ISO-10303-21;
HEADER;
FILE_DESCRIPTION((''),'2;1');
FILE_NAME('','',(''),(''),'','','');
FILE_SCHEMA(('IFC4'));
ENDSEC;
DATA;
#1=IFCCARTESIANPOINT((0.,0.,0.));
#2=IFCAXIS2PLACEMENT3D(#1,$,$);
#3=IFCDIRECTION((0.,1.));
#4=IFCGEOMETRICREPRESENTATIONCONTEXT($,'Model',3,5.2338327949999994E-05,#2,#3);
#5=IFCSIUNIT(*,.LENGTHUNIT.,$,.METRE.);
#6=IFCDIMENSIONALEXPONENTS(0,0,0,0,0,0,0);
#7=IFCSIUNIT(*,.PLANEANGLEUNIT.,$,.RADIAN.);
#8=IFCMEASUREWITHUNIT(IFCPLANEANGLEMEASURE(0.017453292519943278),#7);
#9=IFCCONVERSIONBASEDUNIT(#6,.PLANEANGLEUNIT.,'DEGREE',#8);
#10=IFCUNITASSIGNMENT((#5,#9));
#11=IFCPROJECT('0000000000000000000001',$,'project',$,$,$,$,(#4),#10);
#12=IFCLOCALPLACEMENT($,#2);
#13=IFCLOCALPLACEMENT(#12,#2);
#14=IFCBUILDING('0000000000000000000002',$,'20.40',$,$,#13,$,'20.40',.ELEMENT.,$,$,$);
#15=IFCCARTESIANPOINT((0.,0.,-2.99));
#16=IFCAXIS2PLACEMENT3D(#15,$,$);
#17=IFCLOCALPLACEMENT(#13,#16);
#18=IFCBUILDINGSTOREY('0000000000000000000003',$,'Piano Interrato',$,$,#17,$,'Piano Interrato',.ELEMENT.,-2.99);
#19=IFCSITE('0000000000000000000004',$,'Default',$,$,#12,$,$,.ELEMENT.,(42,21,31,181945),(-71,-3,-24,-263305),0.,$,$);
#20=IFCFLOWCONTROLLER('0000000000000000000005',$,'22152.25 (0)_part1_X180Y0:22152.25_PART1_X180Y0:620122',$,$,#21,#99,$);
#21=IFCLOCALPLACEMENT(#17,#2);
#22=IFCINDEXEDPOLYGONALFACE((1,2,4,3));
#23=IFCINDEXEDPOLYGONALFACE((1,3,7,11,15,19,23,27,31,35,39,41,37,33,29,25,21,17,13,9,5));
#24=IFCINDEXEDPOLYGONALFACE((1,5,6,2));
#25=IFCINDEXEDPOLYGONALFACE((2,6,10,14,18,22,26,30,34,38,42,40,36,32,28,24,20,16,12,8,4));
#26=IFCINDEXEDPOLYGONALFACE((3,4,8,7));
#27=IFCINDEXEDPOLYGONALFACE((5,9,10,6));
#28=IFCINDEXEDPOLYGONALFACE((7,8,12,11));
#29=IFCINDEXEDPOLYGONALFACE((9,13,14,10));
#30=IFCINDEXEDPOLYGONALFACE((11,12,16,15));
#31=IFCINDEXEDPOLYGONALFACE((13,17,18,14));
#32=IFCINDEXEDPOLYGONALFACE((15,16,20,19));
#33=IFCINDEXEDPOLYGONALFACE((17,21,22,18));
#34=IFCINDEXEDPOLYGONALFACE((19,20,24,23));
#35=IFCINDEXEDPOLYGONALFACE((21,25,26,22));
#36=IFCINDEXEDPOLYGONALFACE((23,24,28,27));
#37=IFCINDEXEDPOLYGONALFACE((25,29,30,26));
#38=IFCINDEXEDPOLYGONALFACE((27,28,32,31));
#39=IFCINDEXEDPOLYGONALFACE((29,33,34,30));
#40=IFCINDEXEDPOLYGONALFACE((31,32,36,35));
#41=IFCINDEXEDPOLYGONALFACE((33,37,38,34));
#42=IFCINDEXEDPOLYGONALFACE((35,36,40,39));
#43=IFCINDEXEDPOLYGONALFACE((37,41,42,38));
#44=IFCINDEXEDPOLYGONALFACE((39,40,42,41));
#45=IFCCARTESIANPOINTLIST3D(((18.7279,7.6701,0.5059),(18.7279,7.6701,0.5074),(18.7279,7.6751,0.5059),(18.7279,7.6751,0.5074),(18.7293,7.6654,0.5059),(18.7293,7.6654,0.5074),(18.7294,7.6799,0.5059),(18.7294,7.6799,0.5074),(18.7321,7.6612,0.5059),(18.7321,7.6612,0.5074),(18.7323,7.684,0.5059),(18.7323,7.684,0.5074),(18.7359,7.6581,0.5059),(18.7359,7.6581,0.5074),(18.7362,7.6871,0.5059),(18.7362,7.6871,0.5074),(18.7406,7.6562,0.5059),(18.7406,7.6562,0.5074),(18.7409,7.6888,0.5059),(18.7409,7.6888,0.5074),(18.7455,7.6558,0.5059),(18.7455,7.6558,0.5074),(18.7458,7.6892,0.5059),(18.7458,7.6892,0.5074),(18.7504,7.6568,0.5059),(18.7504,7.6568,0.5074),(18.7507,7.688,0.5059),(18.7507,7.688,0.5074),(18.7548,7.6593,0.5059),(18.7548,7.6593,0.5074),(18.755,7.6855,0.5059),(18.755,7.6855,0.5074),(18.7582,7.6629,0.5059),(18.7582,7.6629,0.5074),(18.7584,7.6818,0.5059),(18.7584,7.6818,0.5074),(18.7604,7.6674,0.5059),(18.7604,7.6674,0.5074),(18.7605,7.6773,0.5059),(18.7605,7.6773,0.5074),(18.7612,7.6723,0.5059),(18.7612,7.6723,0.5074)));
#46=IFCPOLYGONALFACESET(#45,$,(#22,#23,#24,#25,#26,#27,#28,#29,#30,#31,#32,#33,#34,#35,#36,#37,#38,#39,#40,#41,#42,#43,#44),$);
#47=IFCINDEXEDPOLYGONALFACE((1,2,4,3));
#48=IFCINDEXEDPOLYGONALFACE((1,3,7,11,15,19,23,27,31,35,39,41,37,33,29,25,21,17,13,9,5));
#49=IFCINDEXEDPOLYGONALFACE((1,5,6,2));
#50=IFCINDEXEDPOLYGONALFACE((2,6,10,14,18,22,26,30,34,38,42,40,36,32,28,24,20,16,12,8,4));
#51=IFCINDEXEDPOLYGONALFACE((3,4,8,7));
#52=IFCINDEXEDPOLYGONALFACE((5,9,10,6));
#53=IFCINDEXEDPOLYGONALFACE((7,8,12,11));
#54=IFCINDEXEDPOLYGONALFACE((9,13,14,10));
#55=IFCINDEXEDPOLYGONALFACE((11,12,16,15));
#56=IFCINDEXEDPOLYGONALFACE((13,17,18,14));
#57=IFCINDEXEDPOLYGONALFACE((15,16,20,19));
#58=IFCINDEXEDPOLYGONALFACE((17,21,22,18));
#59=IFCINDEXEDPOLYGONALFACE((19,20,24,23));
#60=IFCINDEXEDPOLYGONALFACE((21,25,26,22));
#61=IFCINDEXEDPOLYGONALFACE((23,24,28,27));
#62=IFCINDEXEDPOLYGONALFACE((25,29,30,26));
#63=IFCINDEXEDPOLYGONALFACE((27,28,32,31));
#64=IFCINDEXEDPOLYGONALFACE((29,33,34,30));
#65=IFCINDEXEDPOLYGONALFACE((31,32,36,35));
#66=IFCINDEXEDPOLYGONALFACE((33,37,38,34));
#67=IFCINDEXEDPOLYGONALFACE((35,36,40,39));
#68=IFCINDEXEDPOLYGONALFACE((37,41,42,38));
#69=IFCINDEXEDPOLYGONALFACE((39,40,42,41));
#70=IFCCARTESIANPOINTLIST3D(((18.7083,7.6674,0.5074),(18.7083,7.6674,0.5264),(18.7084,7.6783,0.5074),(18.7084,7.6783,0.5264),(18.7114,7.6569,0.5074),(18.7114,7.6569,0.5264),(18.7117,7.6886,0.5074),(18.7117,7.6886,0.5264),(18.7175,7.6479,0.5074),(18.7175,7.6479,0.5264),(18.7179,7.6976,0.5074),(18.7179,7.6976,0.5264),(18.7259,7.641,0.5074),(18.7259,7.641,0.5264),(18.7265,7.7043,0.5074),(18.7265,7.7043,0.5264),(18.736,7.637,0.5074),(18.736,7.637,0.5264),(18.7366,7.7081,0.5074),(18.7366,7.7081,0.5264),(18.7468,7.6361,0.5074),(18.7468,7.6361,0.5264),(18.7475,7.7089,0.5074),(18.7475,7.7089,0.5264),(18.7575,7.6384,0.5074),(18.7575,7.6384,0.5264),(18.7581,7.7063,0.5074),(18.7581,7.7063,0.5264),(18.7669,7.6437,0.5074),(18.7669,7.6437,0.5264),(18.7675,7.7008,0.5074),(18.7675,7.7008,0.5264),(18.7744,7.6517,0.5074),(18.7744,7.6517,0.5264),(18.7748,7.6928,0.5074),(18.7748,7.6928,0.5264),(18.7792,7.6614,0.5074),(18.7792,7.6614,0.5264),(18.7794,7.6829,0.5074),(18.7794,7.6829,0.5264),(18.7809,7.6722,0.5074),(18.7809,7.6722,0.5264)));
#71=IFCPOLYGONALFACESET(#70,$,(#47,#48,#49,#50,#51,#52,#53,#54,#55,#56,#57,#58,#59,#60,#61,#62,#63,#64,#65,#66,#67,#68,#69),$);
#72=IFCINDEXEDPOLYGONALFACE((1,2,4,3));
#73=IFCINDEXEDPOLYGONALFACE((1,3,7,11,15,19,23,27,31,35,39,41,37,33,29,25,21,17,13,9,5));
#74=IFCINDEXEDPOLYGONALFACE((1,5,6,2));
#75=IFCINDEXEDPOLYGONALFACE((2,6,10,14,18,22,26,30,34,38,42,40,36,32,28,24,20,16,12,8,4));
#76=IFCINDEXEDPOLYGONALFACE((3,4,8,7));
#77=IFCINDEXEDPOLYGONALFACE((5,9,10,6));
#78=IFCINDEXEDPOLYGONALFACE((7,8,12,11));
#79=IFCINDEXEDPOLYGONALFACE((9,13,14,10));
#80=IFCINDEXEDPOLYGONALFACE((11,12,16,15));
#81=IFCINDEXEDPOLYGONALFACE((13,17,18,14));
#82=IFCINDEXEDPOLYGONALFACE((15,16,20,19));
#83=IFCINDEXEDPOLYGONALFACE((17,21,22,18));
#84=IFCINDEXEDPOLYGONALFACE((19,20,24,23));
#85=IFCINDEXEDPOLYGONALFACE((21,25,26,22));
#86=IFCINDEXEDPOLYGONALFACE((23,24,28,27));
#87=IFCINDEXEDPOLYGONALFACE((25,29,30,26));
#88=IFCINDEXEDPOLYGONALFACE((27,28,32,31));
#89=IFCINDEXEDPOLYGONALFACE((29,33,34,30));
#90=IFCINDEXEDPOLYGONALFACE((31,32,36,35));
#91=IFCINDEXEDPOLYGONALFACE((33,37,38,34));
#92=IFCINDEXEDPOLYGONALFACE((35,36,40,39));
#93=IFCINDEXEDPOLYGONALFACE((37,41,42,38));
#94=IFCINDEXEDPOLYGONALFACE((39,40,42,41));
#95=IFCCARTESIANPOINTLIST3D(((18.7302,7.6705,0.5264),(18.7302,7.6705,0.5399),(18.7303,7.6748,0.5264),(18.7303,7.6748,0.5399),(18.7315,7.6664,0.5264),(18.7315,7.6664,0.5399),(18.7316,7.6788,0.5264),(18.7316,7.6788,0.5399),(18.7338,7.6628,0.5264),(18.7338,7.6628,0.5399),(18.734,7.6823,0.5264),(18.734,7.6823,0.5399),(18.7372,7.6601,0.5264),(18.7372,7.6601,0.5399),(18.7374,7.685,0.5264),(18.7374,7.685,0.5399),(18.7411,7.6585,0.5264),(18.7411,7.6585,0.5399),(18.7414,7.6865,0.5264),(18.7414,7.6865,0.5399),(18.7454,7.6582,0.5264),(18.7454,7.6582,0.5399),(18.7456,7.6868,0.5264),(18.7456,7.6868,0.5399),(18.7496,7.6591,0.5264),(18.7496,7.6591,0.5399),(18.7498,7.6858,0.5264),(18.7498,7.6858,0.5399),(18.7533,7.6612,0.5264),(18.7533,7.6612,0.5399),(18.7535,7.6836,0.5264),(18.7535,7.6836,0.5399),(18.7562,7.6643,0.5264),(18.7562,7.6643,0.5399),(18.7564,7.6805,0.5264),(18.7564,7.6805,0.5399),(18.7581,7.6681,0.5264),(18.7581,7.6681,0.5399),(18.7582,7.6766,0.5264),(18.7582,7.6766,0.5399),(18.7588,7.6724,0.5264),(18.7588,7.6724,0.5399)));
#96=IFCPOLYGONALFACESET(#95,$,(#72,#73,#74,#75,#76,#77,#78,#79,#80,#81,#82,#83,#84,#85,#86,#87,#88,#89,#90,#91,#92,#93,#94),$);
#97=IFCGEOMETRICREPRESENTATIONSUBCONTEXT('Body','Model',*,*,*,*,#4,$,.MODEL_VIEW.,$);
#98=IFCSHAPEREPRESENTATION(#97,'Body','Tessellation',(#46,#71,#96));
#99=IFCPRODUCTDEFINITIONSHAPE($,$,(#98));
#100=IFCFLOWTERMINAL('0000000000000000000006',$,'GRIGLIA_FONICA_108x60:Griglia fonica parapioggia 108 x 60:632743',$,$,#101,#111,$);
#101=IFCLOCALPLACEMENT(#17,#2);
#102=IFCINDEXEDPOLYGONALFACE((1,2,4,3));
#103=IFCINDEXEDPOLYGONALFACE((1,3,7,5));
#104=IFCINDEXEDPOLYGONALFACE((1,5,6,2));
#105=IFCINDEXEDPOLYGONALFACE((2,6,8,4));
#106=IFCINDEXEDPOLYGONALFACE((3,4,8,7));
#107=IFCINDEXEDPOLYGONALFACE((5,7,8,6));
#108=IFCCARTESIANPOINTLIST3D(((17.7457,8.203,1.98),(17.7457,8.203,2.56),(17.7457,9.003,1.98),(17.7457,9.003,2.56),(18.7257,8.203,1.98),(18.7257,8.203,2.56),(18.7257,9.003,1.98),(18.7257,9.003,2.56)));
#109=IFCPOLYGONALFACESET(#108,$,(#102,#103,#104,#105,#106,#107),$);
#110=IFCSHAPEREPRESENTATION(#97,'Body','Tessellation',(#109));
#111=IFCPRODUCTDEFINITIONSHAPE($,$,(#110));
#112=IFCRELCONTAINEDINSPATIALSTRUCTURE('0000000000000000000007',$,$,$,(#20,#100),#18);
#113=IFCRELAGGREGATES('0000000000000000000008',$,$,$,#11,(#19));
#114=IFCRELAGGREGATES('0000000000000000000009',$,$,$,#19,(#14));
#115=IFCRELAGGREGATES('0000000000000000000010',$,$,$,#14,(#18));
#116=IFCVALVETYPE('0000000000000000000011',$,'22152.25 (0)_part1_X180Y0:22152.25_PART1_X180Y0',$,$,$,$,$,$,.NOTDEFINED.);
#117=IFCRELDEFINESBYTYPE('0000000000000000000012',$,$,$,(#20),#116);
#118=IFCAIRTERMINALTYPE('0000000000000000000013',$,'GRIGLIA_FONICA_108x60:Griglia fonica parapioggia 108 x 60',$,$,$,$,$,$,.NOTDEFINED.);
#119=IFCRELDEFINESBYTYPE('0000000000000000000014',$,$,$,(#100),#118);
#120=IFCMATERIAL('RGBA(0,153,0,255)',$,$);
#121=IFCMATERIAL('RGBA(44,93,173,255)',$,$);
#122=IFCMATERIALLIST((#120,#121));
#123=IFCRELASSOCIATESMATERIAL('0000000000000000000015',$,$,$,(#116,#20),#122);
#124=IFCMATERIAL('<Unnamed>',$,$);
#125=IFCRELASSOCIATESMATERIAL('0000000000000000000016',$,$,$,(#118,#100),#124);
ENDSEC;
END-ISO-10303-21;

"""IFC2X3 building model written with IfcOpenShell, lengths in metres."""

from ifc_helpers import new_model, entity, si_unit, converted_unit, direction, frame, frame_2d, origin, origin_2d_with_axis, place, context, subcontext, project, spatial, rectangle, circle, extrude, source, transform, mapped, material, material_list, type_object, type_shapes, element, save


model = new_model("IFC2X3")

# Units and contexts
model_context = context("Model", 3, precision=5.2338327949999994e-05, world=origin(), true_north=direction((0.0, 1.0)))
body_context = subcontext(model_context, "Body", "Model", "MODEL_VIEW")
ifc_project = project(units=[si_unit("LENGTHUNIT", "METRE"), converted_unit("PLANEANGLEUNIT", "DEGREE", entity("IfcPlaneAngleMeasure", 0.017453292519943278), si_unit("PLANEANGLEUNIT", "RADIAN"), dimensions=[0, 0, 0, 0, 0, 0, 0])], contexts=[model_context])

# Site, building, storey
site_placement = place(None, origin())
site = spatial("IfcSite", under=ifc_project, at=site_placement, Name="Default", CompositionType="ELEMENT", RefLatitude=(42, 21, 31, 181945), RefLongitude=(-71, -3, -24, -263305), RefElevation=0.0)
building_placement = place(site_placement, origin())
building = spatial("IfcBuilding", under=site, at=building_placement, Name="20.40", LongName="20.40", CompositionType="ELEMENT")
storey_placement = place(building_placement, frame((0.0, 0.0, -2.99)))
storey = spatial("IfcBuildingStorey", under=building, at=storey_placement, Name="Piano Interrato", LongName="Piano Interrato", CompositionType="ELEMENT", Elevation=-2.99)

# Shared definitions
ifc_material_1 = material(Name="<Unnamed>")

# Flow controller
ifc_material_2 = material(Name="RGBA(0,153,0,255)")
ifc_material_3 = material(Name="RGBA(44,93,173,255)")
ifc_material_list_1 = material_list([ifc_material_2, ifc_material_3])
valve_type_1 = type_object("IfcValveType", Name="22152.25 (0)_part1_X180Y0:22152.25_PART1_X180Y0", PredefinedType="NOTDEFINED", material=ifc_material_list_1)
shared_shape_1 = source(origin(), body_context, "Body", "SweptSolid", [
    extrude(circle(Radius=0.0168, at=frame_2d((0.0, 0.0), x_axis=(1.0, 0.0))), frame((0.0, 0.0, -0.034), z_axis=(0.0, 0.0, 1.0), x_axis=(0.0, -1.0, 0.0)), (0.0, 0.0, 1.0), 0.0015),
    extrude(circle(Radius=0.0365, at=frame_2d((0.0, 0.0), x_axis=(1.0, 0.0))), frame((0.0, 0.0, -0.0325), z_axis=(0.0, 0.0, 1.0), x_axis=(0.0, -1.0, 0.0)), (0.0, 0.0, 1.0), 0.019),
    extrude(circle(Radius=0.0144, at=frame_2d((0.0, 0.0), x_axis=(1.0, 0.0))), frame((0.0, 0.0, -0.0135), z_axis=(0.0, 0.0, 1.0), x_axis=(0.0, -1.0, 0.0)), (0.0, 0.0, 1.0), 0.0135),
])
type_shapes(valve_type_1, [shared_shape_1])
flow_controller_1_placement = place(storey_placement, frame((18.7444, 7.6725, 0.5399), z_axis=(0.0, 0.0, 1.0), x_axis=(0.009014, 0.999959, 0.0)))
element("IfcFlowController", 1, at=flow_controller_1_placement, inside=storey, type_object=valve_type_1, material=ifc_material_list_1, Name="22152.25 (0)_part1_X180Y0:22152.25_PART1_X180Y0:620122", context=body_context, shape_type="MappedRepresentation", body=[
    mapped(shared_shape_1, transform((0.0, 0.0, 0.0), scale=1.0)),
])

# Flow terminal
air_terminal_type = type_object("IfcAirTerminalType", Name="GRIGLIA_FONICA_108x60:Griglia fonica parapioggia 108 x 60", PredefinedType="NOTDEFINED", material=ifc_material_1)
shared_shape_2 = source(origin(), body_context, "Body", "SweptSolid", [
    extrude(rectangle(XDim=0.8, YDim=0.98, at=origin_2d_with_axis()), frame((0.0, 0.4, -0.29), z_axis=(0.0, 0.0, 1.0), x_axis=(0.0, -1.0, 0.0)), (0.0, 0.0, 1.0), 0.58),
])
type_shapes(air_terminal_type, [shared_shape_2])
flow_terminal_placement = place(storey_placement, frame((18.2357, 8.203, 2.27)))
element("IfcFlowTerminal", 2, at=flow_terminal_placement, inside=storey, type_object=air_terminal_type, material=ifc_material_1, Name="GRIGLIA_FONICA_108x60:Griglia fonica parapioggia 108 x 60:632743", context=body_context, shape_type="MappedRepresentation", body=[
    mapped(shared_shape_2, transform((0.0, 0.0, 0.0), scale=1.0)),
])

save(model, "model.ifc")
